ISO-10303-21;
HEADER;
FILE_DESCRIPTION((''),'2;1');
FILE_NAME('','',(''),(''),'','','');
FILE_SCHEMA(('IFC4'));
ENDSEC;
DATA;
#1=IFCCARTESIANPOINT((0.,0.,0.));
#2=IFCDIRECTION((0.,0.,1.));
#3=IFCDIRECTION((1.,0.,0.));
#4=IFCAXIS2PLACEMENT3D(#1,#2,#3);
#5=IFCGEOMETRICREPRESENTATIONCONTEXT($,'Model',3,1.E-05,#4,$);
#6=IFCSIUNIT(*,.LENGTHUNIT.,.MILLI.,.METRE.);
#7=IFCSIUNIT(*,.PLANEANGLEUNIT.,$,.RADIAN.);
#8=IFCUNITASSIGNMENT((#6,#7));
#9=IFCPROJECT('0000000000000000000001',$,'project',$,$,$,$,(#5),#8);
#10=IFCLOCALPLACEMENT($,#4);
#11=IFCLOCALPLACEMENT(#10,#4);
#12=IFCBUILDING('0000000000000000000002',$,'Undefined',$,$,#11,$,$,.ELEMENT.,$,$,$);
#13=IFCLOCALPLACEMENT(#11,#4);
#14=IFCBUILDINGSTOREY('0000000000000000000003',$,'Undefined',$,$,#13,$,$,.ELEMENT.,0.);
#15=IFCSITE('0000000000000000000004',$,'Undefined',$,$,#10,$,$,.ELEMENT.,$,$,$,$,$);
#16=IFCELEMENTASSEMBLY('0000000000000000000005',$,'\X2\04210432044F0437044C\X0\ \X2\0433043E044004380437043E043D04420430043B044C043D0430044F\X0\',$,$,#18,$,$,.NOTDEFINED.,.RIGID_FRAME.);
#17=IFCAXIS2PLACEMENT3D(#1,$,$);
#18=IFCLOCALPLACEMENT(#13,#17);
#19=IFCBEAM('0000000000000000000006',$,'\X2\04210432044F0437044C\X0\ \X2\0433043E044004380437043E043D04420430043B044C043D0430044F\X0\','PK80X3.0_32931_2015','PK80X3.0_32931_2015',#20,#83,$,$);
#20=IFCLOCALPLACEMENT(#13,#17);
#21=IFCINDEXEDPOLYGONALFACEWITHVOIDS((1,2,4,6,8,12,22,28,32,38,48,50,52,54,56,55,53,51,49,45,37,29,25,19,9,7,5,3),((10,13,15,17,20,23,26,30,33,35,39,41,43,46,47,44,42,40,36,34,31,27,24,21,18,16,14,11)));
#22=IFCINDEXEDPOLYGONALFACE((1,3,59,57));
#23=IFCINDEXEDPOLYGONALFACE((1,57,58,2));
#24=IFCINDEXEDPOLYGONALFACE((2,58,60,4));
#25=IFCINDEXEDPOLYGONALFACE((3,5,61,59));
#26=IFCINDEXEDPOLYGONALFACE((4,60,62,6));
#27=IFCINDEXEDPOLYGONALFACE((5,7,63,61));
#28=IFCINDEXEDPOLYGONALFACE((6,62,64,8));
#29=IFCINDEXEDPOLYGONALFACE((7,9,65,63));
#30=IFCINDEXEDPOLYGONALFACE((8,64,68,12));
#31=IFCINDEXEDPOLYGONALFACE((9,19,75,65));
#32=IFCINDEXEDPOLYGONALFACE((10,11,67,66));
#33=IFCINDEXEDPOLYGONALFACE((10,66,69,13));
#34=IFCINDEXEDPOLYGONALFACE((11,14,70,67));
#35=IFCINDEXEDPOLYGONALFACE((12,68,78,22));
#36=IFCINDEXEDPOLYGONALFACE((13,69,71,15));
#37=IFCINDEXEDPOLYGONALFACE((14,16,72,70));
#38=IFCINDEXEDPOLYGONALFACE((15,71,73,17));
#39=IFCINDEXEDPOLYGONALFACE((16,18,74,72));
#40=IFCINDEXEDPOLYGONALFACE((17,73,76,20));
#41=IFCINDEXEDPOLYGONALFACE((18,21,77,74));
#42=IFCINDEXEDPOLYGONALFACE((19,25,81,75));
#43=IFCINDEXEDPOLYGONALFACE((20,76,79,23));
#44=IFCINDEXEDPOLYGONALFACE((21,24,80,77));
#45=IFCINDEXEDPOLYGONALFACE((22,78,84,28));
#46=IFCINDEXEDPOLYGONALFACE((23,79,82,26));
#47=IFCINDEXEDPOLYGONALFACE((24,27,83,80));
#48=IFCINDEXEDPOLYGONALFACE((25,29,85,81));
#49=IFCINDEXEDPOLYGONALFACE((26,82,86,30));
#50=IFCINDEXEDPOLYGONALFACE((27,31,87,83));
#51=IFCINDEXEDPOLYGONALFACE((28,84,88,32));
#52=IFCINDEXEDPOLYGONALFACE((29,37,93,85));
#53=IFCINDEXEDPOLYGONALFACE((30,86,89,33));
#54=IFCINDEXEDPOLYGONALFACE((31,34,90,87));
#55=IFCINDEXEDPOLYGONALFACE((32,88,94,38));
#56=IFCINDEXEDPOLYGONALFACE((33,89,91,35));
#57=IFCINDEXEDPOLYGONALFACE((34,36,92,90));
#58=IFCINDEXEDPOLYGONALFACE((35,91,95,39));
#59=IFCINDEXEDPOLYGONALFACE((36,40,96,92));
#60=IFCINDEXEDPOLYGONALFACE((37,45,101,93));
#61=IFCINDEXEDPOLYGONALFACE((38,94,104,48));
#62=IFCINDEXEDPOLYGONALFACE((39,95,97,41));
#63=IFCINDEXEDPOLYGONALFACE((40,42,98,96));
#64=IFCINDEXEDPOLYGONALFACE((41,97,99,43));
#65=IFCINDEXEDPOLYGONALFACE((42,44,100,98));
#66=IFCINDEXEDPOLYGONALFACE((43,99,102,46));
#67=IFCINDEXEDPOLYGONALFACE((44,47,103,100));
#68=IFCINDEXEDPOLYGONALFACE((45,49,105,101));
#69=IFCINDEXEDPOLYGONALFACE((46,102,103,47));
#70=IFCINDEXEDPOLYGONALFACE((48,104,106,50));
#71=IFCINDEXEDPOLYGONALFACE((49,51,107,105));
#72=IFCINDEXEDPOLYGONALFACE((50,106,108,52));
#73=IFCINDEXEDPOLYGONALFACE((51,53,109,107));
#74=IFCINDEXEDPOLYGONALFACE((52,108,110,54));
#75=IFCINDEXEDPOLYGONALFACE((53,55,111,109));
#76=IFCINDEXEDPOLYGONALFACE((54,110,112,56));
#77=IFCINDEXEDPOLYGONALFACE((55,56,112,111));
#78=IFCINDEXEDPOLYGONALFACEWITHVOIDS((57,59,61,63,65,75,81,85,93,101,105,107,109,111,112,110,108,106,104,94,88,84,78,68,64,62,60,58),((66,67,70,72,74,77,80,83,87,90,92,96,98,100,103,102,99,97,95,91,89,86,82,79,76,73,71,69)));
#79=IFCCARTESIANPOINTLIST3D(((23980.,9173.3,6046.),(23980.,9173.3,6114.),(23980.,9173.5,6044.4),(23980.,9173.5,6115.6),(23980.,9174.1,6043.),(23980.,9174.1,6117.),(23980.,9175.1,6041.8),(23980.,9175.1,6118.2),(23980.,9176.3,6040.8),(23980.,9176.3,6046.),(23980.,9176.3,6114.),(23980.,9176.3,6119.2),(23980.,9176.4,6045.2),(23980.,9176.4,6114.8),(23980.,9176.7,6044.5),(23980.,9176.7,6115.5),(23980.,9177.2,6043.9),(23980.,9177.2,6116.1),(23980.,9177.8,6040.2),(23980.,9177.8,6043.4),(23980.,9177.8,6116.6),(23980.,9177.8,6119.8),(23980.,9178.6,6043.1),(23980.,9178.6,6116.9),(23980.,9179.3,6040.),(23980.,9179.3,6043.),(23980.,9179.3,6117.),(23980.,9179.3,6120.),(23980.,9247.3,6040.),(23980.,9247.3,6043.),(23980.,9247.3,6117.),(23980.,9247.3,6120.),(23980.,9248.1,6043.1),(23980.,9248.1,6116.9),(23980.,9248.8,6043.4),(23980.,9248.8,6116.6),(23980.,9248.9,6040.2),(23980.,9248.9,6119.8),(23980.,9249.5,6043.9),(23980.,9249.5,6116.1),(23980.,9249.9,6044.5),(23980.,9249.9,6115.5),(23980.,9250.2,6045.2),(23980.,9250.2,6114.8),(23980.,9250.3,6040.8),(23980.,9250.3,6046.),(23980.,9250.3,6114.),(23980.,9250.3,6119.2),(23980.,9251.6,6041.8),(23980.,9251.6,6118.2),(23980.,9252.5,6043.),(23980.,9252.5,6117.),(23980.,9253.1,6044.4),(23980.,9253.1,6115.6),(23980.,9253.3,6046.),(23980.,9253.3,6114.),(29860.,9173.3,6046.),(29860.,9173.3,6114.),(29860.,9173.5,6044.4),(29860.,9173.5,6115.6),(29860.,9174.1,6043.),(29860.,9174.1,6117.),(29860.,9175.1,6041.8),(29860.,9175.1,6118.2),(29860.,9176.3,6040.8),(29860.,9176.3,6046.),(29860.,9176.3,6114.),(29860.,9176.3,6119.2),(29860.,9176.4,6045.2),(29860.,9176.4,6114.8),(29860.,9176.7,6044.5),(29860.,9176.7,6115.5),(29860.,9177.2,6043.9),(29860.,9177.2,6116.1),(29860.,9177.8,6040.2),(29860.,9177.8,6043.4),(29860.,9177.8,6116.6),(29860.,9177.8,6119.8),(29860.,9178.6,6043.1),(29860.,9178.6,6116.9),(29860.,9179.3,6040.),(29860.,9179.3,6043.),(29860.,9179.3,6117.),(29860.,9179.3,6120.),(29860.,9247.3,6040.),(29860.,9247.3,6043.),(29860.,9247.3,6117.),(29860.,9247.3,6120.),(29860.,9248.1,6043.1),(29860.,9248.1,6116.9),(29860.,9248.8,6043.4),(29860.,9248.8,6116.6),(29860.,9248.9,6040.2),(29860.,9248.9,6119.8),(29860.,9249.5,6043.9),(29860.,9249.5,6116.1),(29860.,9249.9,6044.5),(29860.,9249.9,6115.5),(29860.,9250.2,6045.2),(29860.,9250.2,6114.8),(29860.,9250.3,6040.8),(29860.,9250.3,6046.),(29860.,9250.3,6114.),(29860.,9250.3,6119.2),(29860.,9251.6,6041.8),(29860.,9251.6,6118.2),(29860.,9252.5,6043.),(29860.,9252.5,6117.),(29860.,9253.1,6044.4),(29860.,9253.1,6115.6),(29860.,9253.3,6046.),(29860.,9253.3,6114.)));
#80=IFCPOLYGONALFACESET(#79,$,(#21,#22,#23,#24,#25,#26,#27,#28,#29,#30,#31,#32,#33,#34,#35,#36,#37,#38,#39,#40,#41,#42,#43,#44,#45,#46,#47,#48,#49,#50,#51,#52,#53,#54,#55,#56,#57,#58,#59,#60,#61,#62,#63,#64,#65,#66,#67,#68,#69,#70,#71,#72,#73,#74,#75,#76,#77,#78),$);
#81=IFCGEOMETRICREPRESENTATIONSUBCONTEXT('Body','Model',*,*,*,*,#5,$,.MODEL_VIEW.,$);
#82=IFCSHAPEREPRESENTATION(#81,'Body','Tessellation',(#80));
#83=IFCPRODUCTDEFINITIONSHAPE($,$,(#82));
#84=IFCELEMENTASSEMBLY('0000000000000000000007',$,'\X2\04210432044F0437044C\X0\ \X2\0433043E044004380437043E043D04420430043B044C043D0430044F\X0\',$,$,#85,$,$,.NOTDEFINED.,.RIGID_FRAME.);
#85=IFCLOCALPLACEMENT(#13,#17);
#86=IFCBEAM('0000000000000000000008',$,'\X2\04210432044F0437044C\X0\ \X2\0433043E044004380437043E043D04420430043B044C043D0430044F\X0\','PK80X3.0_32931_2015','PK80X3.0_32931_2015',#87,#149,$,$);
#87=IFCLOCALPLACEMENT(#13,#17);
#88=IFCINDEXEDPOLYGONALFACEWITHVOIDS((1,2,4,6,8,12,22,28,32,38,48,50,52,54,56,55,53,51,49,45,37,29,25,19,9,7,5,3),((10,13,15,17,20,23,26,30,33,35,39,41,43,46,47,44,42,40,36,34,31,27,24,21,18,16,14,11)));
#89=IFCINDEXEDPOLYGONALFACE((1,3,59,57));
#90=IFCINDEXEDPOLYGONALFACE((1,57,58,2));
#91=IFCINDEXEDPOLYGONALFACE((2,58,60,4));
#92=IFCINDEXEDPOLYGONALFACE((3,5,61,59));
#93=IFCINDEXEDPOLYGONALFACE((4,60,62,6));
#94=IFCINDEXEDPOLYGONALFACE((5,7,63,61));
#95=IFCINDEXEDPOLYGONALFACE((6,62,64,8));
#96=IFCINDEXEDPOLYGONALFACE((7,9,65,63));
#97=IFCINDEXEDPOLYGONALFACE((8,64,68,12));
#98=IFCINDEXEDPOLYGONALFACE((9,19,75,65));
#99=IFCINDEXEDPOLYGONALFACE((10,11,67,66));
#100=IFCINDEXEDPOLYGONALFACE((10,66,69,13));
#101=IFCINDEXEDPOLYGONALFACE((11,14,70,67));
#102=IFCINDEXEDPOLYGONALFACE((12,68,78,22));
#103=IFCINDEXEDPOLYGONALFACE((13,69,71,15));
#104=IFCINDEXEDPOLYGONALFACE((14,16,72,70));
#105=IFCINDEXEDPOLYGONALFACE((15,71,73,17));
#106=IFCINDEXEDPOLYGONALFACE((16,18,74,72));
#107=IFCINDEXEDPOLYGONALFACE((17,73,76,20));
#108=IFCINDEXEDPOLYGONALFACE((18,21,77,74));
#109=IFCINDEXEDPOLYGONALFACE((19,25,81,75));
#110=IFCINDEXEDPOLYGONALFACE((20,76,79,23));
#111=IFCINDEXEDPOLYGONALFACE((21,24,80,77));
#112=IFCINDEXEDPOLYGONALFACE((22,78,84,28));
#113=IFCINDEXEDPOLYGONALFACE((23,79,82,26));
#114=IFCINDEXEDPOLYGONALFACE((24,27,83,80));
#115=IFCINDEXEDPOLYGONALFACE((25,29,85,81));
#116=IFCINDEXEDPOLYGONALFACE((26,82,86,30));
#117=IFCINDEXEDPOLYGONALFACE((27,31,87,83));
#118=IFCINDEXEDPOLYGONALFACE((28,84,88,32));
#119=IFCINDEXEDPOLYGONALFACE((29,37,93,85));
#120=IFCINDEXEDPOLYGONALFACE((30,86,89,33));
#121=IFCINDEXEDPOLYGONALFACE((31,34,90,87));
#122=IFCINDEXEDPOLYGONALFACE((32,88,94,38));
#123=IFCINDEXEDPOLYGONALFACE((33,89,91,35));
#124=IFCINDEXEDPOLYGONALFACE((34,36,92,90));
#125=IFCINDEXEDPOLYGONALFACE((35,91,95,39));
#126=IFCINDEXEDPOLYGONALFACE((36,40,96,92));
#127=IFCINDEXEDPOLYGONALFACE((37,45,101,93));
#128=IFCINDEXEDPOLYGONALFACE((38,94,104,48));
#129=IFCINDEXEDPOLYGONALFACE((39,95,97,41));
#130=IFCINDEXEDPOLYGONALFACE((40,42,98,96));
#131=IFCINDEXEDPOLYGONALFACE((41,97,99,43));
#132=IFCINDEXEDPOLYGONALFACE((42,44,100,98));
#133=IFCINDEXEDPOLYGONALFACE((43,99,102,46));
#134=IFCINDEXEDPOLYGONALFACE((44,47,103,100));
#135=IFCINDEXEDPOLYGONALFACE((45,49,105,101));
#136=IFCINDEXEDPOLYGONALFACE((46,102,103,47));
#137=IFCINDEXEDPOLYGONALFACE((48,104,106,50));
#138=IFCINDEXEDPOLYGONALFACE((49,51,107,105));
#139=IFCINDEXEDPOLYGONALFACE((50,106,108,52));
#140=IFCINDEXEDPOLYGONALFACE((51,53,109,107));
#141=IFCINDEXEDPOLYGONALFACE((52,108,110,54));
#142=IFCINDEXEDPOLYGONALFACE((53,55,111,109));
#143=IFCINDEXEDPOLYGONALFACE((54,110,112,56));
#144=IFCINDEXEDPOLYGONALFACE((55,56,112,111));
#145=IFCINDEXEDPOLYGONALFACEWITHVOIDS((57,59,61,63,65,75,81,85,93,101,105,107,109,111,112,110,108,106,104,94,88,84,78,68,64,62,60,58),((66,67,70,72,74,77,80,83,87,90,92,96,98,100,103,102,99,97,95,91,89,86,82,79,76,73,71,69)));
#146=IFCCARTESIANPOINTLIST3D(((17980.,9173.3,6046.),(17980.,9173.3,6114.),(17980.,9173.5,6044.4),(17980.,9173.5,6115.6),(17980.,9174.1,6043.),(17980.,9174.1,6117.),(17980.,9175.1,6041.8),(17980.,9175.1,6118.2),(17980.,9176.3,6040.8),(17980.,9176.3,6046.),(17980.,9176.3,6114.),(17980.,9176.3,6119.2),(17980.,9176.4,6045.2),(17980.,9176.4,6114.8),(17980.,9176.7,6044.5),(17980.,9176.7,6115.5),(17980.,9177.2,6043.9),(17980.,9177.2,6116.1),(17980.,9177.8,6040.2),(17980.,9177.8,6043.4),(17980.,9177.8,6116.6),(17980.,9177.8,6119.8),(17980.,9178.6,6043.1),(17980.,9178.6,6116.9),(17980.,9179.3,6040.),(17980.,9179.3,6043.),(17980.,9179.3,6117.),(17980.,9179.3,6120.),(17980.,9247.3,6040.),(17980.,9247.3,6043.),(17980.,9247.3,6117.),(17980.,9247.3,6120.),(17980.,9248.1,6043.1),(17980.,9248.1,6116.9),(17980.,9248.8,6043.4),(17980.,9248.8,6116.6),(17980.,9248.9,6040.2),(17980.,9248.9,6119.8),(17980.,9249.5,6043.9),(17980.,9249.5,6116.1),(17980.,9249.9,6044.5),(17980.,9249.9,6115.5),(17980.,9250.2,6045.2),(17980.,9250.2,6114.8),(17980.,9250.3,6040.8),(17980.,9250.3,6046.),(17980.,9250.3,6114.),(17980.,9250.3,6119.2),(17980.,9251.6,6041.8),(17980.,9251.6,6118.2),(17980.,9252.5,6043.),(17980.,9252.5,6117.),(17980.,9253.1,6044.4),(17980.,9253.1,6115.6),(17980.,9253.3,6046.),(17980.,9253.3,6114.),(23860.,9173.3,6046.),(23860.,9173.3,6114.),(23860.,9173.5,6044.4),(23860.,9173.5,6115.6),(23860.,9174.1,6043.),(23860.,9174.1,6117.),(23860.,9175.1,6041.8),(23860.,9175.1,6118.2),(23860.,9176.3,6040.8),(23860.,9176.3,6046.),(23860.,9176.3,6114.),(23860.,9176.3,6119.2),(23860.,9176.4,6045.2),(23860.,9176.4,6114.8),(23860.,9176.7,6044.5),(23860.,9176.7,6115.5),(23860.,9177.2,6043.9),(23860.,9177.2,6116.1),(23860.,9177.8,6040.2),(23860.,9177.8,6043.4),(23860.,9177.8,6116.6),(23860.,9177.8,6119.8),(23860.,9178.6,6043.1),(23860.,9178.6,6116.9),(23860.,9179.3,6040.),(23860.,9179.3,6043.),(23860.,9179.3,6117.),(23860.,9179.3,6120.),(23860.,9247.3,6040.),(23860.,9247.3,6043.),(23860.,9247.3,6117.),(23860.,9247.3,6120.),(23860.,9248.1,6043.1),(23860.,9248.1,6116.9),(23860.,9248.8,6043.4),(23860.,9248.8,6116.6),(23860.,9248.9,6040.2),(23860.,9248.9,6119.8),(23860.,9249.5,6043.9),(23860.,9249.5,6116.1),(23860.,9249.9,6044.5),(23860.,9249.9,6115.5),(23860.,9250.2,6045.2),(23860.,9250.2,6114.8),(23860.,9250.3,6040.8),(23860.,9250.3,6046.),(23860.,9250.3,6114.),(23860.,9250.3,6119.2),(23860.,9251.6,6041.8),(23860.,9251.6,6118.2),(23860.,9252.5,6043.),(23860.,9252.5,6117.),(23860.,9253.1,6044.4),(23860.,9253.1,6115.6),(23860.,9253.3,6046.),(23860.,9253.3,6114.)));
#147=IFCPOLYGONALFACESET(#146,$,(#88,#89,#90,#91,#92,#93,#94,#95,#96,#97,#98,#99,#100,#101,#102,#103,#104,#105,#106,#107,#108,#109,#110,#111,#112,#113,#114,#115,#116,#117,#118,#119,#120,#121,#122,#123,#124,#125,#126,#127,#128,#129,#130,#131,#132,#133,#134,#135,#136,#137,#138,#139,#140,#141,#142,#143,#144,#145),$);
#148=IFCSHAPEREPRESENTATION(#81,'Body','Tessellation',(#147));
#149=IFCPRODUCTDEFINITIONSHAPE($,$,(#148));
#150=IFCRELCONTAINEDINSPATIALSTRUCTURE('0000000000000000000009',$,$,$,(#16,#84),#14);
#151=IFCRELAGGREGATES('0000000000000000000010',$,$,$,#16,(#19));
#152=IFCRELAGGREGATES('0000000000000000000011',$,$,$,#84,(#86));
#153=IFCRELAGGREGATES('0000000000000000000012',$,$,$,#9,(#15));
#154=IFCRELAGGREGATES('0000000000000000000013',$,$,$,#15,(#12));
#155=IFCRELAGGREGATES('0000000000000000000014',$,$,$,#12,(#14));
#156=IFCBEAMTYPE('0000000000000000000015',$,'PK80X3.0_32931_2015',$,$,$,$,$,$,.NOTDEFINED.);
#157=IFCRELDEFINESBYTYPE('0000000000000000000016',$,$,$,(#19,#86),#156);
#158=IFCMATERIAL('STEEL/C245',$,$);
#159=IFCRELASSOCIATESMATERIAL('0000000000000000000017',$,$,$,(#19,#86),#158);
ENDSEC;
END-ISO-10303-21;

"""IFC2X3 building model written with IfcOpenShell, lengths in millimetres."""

from ifc_helpers import new_model, si_unit, frame, origin_with_axes, origin_2d_with_axis, place, context, subcontext, project, spatial, hollow_rectangle, extrude, material, type_object, element, aggregate, save


model = new_model("IFC2X3")

# Units and contexts
model_context = context("Model", 3, precision=1e-05, world=origin_with_axes())
body_context = subcontext(model_context, "Body", "Model", "MODEL_VIEW")
ifc_project = project(units=[si_unit("LENGTHUNIT", "METRE", prefix="MILLI"), si_unit("PLANEANGLEUNIT", "RADIAN")], contexts=[model_context])

# Site, building, storey
site_placement = place(None, origin_with_axes())
site = spatial("IfcSite", under=ifc_project, at=site_placement, Name="Undefined", CompositionType="ELEMENT")
building_placement = place(site_placement, origin_with_axes())
building = spatial("IfcBuilding", under=site, at=building_placement, Name="Undefined", CompositionType="ELEMENT")
storey_placement = place(building_placement, origin_with_axes())
storey = spatial("IfcBuildingStorey", under=building, at=storey_placement, Name="Undefined", CompositionType="ELEMENT", Elevation=0.0)

# Shared definitions
ifc_material = material(Name="STEEL/C245")

# Element assemblies, beams
assembly_1_placement = place(storey_placement, origin_with_axes())
assembly_1 = element("IfcElementAssembly", 1, at=assembly_1_placement, inside=storey, Name="Связь горизонтальная", AssemblyPlace="NOTDEFINED", PredefinedType="RIGID_FRAME")
beam_type_1 = type_object("IfcBeamType", Name="PK80X3.0_32931_2015", PredefinedType="NOTDEFINED")
beam_1_placement = place(assembly_1_placement, frame((23980.0, 9213.3, 6080.0), z_axis=(0.0, 0.0, 1.0), x_axis=(1.0, 0.0, 0.0)))
beam_1 = element("IfcBeam", 2, at=beam_1_placement, type_object=beam_type_1, material=ifc_material, Name="Связь горизонтальная", Description="PK80X3.0_32931_2015", ObjectType="PK80X3.0_32931_2015", context=body_context, shape_type="SweptSolid", body=[
    extrude(hollow_rectangle(XDim=80.0, YDim=80.0, WallThickness=3.0, InnerFilletRadius=3.0, OuterFilletRadius=6.0, at=origin_2d_with_axis()), frame((5880.0, 0.0, 0.0), z_axis=(-1.0, 0.0, 0.0), x_axis=(0.0, -1.0, 0.0)), (0.0, 0.0, 1.0), 5880.0),
])
aggregate(assembly_1, [beam_1])
assembly_2_placement = place(storey_placement, origin_with_axes())
assembly_2 = element("IfcElementAssembly", 3, at=assembly_2_placement, inside=storey, Name="Связь горизонтальная", AssemblyPlace="NOTDEFINED", PredefinedType="RIGID_FRAME")
beam_2_placement = place(assembly_2_placement, frame((17980.0, 9213.3, 6080.0), z_axis=(0.0, 0.0, 1.0), x_axis=(1.0, 0.0, 0.0)))
beam_2 = element("IfcBeam", 4, at=beam_2_placement, type_object=beam_type_1, material=ifc_material, Name="Связь горизонтальная", Description="PK80X3.0_32931_2015", ObjectType="PK80X3.0_32931_2015", context=body_context, shape_type="SweptSolid", body=[
    extrude(hollow_rectangle(XDim=80.0, YDim=80.0, WallThickness=3.0, InnerFilletRadius=3.0, OuterFilletRadius=6.0, at=origin_2d_with_axis()), frame((5880.0, 0.0, 0.0), z_axis=(-1.0, 0.0, 0.0), x_axis=(0.0, -1.0, 0.0)), (0.0, 0.0, 1.0), 5880.0),
])
aggregate(assembly_2, [beam_2])

save(model, "model.ifc")
